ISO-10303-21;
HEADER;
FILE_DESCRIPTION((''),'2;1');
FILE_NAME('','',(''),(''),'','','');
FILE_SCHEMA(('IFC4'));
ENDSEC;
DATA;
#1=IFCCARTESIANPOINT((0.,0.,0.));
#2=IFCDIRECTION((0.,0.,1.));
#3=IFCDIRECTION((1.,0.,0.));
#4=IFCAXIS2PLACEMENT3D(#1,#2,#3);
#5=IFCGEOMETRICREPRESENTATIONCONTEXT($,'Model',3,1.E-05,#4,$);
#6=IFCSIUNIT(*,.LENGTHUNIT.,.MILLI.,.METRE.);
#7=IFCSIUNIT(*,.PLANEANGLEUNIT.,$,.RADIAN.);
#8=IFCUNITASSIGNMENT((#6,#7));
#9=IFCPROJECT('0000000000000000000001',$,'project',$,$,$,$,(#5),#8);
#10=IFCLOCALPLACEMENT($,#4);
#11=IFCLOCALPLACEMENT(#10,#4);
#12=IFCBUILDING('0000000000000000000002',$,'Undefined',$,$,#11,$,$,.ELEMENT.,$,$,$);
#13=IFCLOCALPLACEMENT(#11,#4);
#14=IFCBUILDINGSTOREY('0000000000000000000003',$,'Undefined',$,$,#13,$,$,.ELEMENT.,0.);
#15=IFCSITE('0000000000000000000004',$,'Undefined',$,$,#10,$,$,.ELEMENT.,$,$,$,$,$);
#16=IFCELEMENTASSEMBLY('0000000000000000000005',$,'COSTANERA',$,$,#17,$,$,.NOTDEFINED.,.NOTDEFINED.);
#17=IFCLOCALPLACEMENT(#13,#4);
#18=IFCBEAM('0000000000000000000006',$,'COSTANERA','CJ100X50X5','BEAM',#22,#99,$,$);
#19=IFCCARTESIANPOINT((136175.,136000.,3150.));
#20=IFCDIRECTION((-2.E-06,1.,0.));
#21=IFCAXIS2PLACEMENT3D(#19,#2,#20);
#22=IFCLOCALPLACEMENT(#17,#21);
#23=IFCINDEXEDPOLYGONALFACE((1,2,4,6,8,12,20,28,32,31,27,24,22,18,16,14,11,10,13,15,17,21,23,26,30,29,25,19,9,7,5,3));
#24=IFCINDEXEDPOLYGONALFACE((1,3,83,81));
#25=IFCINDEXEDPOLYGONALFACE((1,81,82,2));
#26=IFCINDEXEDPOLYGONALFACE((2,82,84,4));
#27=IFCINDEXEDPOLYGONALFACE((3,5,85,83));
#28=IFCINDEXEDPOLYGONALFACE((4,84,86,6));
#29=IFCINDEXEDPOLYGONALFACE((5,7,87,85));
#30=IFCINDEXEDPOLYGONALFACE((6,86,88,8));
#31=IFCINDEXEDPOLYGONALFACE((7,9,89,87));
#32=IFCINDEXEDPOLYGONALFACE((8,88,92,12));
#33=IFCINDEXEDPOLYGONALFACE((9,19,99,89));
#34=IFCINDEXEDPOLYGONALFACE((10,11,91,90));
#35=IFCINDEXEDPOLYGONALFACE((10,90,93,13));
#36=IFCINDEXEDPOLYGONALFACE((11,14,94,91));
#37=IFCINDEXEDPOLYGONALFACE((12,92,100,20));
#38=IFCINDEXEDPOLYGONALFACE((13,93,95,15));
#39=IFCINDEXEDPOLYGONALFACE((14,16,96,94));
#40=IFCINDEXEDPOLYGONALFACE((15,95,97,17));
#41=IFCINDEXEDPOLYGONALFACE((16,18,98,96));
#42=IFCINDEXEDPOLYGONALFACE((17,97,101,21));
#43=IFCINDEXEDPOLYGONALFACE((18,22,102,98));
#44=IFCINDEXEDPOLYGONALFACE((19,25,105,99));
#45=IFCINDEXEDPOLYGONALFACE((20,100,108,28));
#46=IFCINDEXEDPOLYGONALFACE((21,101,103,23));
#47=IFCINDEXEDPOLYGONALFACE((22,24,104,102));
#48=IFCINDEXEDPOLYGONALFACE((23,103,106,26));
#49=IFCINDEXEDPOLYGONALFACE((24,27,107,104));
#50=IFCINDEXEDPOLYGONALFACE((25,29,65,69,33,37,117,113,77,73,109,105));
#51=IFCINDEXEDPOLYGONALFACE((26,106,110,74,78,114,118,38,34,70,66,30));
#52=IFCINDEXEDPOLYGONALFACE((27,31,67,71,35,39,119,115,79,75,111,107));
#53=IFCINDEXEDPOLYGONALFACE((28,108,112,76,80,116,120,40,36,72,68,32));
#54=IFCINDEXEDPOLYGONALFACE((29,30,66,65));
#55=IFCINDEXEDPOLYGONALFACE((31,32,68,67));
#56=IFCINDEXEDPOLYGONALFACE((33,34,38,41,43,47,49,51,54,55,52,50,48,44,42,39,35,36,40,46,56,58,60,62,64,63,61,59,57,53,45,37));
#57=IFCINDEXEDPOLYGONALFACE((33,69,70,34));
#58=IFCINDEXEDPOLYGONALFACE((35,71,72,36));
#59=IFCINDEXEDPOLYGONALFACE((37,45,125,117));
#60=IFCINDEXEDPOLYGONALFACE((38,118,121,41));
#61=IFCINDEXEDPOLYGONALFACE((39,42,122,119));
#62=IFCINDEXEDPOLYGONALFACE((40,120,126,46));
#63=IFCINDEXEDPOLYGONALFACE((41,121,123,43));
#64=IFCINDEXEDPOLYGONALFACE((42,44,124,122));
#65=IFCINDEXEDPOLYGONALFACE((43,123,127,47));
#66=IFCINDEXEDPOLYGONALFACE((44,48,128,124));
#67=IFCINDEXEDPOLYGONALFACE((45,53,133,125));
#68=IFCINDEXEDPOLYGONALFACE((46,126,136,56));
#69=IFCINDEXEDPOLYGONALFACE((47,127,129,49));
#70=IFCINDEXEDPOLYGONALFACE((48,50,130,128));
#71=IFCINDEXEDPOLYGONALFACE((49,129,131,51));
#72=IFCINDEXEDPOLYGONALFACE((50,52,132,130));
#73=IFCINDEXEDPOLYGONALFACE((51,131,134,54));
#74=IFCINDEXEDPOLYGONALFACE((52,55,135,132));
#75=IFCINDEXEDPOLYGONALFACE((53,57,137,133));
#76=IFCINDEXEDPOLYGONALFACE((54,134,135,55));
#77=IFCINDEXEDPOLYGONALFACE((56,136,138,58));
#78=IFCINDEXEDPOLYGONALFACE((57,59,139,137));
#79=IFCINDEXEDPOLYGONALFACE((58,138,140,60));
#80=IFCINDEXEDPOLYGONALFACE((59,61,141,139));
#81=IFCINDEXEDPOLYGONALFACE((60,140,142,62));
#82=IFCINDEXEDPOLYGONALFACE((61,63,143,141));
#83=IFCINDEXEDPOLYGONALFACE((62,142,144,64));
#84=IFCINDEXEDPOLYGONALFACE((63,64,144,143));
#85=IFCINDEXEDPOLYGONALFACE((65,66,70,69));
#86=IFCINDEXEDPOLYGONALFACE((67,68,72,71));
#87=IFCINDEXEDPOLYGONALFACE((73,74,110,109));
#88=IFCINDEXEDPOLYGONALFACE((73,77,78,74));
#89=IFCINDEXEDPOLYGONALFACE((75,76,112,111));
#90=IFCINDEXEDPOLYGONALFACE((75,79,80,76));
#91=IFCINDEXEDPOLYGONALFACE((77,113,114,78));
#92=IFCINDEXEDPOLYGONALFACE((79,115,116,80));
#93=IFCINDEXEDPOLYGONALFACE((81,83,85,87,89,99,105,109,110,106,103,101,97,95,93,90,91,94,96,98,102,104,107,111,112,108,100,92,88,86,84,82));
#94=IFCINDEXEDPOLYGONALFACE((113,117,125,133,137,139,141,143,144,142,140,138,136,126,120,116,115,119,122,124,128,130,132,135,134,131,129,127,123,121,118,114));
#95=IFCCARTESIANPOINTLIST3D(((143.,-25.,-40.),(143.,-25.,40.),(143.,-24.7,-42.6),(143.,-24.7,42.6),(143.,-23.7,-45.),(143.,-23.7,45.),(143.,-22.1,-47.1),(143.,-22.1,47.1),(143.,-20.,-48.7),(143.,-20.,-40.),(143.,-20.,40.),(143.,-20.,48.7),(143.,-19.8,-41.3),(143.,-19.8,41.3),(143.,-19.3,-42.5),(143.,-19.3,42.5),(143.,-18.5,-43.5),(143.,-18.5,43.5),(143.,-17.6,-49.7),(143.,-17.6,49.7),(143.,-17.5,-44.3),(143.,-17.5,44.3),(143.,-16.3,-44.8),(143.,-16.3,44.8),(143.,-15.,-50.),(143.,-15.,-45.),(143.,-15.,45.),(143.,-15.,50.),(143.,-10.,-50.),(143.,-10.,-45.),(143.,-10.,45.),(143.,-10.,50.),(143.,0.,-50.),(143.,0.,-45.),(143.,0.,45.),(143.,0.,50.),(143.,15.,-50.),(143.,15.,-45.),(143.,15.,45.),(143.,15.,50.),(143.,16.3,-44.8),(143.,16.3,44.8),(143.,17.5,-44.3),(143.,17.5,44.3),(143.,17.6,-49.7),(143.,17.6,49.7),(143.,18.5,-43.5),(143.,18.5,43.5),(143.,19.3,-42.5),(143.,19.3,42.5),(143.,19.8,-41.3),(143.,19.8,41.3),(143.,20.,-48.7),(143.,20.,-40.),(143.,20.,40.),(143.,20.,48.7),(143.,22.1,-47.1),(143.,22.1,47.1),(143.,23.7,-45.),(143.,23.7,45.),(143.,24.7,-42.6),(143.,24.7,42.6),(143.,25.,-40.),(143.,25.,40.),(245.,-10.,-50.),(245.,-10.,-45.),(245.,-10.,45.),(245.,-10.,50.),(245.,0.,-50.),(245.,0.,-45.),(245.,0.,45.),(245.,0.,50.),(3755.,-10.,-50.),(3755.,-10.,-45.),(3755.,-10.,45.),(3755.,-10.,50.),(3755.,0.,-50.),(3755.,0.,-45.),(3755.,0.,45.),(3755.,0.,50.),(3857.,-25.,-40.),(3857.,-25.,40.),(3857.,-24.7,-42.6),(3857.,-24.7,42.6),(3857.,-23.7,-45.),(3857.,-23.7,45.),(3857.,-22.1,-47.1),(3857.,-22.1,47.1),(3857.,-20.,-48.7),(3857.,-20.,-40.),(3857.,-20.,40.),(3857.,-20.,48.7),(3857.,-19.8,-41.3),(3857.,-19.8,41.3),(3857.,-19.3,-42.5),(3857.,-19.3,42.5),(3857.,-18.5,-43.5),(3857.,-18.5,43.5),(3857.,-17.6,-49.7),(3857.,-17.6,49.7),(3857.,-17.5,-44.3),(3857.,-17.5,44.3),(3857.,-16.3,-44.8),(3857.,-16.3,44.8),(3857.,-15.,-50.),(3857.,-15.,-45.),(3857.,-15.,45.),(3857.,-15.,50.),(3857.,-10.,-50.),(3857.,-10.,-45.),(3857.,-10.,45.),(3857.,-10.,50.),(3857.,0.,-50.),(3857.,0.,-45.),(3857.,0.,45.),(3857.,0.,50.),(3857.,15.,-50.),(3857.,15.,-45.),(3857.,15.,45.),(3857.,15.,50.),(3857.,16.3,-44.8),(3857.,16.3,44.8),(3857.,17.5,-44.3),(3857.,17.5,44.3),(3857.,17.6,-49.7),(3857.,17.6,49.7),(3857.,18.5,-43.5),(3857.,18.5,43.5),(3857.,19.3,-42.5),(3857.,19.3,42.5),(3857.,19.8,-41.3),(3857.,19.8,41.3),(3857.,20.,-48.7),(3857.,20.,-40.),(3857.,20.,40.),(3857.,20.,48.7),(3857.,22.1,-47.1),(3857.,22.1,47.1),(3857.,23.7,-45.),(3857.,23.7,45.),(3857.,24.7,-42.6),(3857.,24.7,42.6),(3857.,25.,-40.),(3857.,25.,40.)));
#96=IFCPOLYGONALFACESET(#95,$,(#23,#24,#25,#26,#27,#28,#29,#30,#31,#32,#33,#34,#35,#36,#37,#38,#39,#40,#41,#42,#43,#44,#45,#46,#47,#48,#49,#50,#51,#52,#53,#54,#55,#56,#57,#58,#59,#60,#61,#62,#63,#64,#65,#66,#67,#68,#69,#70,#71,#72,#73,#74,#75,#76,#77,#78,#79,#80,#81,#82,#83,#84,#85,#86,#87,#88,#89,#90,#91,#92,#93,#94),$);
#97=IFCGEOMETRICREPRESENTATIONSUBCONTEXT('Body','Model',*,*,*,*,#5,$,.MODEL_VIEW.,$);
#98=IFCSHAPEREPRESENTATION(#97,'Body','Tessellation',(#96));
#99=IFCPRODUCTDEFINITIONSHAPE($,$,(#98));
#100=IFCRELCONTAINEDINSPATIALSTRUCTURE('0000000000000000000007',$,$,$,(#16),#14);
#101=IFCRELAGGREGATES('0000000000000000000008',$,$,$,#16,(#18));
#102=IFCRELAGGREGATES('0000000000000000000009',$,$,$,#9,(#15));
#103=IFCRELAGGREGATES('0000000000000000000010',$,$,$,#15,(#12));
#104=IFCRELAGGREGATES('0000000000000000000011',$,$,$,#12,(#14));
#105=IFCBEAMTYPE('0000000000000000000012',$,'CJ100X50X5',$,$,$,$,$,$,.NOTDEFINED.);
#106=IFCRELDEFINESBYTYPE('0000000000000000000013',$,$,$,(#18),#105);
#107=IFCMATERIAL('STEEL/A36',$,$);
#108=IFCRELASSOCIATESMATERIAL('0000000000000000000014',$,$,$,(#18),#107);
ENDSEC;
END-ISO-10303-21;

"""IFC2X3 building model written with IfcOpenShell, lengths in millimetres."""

from ifc_helpers import new_model, si_unit, frame, origin_with_axes, origin_2d_with_axis, place, context, subcontext, project, spatial, rectangle, hollow_rectangle, extrude, boolean, halfspace, material, type_object, element, aggregate, save


model = new_model("IFC2X3")

# Units and contexts
model_context = context("Model", 3, precision=1e-05, world=origin_with_axes())
body_context = subcontext(model_context, "Body", "Model", "MODEL_VIEW")
ifc_project = project(units=[si_unit("LENGTHUNIT", "METRE", prefix="MILLI"), si_unit("PLANEANGLEUNIT", "RADIAN")], contexts=[model_context])

# Site, building, storey
site_placement = place(None, origin_with_axes())
site = spatial("IfcSite", under=ifc_project, at=site_placement, Name="Undefined", CompositionType="ELEMENT")
building_placement = place(site_placement, origin_with_axes())
building = spatial("IfcBuilding", under=site, at=building_placement, Name="Undefined", CompositionType="ELEMENT")
storey_placement = place(building_placement, origin_with_axes())
storey = spatial("IfcBuildingStorey", under=building, at=storey_placement, Name="Undefined", CompositionType="ELEMENT", Elevation=0.0)

# Shared definitions
ifc_material_1 = material(Name="STEEL/A36")

# Shared definitions
beam_type_1 = type_object("IfcBeamType", Name="CJ100X50X5", PredefinedType="NOTDEFINED")

# Element assembly, beam
assembly_1_placement = place(storey_placement, origin_with_axes())
assembly_1 = element("IfcElementAssembly", 1, at=assembly_1_placement, inside=storey, Name="COSTANERA", AssemblyPlace="NOTDEFINED", PredefinedType="NOTDEFINED")
beam_1_placement = place(assembly_1_placement, frame((136175.0, 136000.0, 3150.0), z_axis=(0.0, 0.0, 1.0), x_axis=(-0.000002, 1.0, 0.0)))
beam_1 = element("IfcBeam", 2, at=beam_1_placement, type_object=beam_type_1, material=ifc_material_1, Name="COSTANERA", Description="CJ100X50X5", ObjectType="BEAM", context=body_context, shape_type="CSG", body=[
    boolean("DIFFERENCE", boolean("DIFFERENCE", boolean("DIFFERENCE", boolean("DIFFERENCE", extrude(hollow_rectangle(XDim=50.0, YDim=100.0, WallThickness=5.0, InnerFilletRadius=5.0, OuterFilletRadius=10.0, at=origin_2d_with_axis()), frame((4000.0, 0.0, 0.0), z_axis=(-1.0, 0.0, 0.0), x_axis=(0.0, -1.0, 0.0)), (0.0, 0.0, 1.0), 4000.0), extrude(rectangle(XDim=10.0, YDim=104.0, at=origin_2d_with_axis()), frame((3755.0, -5.0, 0.0), z_axis=(1.0, 0.0, 0.0), x_axis=(0.0, 1.0, 0.0)), (0.0, 0.0, 1.0), 120.0)), extrude(rectangle(XDim=10.0, YDim=104.0, at=origin_2d_with_axis()), frame((245.0, -5.0, 0.0), z_axis=(-1.0, 0.000003, 0.0), x_axis=(0.000002, 1.0, 0.0)), (0.0, 0.0, 1.0), 120.0)), halfspace(frame((3857.0, 200.0, 50.0), z_axis=(-1.0, 0.0, 0.0), x_axis=(0.0, -1.0, 0.0)), True)), halfspace(frame((143.0, 200.0, -50.0), z_axis=(1.0, -0.000003, 0.0), x_axis=(-0.000002, -1.0, 0.0)), True)),
])

aggregate(assembly_1, [beam_1])

save(model, "model.ifc")
